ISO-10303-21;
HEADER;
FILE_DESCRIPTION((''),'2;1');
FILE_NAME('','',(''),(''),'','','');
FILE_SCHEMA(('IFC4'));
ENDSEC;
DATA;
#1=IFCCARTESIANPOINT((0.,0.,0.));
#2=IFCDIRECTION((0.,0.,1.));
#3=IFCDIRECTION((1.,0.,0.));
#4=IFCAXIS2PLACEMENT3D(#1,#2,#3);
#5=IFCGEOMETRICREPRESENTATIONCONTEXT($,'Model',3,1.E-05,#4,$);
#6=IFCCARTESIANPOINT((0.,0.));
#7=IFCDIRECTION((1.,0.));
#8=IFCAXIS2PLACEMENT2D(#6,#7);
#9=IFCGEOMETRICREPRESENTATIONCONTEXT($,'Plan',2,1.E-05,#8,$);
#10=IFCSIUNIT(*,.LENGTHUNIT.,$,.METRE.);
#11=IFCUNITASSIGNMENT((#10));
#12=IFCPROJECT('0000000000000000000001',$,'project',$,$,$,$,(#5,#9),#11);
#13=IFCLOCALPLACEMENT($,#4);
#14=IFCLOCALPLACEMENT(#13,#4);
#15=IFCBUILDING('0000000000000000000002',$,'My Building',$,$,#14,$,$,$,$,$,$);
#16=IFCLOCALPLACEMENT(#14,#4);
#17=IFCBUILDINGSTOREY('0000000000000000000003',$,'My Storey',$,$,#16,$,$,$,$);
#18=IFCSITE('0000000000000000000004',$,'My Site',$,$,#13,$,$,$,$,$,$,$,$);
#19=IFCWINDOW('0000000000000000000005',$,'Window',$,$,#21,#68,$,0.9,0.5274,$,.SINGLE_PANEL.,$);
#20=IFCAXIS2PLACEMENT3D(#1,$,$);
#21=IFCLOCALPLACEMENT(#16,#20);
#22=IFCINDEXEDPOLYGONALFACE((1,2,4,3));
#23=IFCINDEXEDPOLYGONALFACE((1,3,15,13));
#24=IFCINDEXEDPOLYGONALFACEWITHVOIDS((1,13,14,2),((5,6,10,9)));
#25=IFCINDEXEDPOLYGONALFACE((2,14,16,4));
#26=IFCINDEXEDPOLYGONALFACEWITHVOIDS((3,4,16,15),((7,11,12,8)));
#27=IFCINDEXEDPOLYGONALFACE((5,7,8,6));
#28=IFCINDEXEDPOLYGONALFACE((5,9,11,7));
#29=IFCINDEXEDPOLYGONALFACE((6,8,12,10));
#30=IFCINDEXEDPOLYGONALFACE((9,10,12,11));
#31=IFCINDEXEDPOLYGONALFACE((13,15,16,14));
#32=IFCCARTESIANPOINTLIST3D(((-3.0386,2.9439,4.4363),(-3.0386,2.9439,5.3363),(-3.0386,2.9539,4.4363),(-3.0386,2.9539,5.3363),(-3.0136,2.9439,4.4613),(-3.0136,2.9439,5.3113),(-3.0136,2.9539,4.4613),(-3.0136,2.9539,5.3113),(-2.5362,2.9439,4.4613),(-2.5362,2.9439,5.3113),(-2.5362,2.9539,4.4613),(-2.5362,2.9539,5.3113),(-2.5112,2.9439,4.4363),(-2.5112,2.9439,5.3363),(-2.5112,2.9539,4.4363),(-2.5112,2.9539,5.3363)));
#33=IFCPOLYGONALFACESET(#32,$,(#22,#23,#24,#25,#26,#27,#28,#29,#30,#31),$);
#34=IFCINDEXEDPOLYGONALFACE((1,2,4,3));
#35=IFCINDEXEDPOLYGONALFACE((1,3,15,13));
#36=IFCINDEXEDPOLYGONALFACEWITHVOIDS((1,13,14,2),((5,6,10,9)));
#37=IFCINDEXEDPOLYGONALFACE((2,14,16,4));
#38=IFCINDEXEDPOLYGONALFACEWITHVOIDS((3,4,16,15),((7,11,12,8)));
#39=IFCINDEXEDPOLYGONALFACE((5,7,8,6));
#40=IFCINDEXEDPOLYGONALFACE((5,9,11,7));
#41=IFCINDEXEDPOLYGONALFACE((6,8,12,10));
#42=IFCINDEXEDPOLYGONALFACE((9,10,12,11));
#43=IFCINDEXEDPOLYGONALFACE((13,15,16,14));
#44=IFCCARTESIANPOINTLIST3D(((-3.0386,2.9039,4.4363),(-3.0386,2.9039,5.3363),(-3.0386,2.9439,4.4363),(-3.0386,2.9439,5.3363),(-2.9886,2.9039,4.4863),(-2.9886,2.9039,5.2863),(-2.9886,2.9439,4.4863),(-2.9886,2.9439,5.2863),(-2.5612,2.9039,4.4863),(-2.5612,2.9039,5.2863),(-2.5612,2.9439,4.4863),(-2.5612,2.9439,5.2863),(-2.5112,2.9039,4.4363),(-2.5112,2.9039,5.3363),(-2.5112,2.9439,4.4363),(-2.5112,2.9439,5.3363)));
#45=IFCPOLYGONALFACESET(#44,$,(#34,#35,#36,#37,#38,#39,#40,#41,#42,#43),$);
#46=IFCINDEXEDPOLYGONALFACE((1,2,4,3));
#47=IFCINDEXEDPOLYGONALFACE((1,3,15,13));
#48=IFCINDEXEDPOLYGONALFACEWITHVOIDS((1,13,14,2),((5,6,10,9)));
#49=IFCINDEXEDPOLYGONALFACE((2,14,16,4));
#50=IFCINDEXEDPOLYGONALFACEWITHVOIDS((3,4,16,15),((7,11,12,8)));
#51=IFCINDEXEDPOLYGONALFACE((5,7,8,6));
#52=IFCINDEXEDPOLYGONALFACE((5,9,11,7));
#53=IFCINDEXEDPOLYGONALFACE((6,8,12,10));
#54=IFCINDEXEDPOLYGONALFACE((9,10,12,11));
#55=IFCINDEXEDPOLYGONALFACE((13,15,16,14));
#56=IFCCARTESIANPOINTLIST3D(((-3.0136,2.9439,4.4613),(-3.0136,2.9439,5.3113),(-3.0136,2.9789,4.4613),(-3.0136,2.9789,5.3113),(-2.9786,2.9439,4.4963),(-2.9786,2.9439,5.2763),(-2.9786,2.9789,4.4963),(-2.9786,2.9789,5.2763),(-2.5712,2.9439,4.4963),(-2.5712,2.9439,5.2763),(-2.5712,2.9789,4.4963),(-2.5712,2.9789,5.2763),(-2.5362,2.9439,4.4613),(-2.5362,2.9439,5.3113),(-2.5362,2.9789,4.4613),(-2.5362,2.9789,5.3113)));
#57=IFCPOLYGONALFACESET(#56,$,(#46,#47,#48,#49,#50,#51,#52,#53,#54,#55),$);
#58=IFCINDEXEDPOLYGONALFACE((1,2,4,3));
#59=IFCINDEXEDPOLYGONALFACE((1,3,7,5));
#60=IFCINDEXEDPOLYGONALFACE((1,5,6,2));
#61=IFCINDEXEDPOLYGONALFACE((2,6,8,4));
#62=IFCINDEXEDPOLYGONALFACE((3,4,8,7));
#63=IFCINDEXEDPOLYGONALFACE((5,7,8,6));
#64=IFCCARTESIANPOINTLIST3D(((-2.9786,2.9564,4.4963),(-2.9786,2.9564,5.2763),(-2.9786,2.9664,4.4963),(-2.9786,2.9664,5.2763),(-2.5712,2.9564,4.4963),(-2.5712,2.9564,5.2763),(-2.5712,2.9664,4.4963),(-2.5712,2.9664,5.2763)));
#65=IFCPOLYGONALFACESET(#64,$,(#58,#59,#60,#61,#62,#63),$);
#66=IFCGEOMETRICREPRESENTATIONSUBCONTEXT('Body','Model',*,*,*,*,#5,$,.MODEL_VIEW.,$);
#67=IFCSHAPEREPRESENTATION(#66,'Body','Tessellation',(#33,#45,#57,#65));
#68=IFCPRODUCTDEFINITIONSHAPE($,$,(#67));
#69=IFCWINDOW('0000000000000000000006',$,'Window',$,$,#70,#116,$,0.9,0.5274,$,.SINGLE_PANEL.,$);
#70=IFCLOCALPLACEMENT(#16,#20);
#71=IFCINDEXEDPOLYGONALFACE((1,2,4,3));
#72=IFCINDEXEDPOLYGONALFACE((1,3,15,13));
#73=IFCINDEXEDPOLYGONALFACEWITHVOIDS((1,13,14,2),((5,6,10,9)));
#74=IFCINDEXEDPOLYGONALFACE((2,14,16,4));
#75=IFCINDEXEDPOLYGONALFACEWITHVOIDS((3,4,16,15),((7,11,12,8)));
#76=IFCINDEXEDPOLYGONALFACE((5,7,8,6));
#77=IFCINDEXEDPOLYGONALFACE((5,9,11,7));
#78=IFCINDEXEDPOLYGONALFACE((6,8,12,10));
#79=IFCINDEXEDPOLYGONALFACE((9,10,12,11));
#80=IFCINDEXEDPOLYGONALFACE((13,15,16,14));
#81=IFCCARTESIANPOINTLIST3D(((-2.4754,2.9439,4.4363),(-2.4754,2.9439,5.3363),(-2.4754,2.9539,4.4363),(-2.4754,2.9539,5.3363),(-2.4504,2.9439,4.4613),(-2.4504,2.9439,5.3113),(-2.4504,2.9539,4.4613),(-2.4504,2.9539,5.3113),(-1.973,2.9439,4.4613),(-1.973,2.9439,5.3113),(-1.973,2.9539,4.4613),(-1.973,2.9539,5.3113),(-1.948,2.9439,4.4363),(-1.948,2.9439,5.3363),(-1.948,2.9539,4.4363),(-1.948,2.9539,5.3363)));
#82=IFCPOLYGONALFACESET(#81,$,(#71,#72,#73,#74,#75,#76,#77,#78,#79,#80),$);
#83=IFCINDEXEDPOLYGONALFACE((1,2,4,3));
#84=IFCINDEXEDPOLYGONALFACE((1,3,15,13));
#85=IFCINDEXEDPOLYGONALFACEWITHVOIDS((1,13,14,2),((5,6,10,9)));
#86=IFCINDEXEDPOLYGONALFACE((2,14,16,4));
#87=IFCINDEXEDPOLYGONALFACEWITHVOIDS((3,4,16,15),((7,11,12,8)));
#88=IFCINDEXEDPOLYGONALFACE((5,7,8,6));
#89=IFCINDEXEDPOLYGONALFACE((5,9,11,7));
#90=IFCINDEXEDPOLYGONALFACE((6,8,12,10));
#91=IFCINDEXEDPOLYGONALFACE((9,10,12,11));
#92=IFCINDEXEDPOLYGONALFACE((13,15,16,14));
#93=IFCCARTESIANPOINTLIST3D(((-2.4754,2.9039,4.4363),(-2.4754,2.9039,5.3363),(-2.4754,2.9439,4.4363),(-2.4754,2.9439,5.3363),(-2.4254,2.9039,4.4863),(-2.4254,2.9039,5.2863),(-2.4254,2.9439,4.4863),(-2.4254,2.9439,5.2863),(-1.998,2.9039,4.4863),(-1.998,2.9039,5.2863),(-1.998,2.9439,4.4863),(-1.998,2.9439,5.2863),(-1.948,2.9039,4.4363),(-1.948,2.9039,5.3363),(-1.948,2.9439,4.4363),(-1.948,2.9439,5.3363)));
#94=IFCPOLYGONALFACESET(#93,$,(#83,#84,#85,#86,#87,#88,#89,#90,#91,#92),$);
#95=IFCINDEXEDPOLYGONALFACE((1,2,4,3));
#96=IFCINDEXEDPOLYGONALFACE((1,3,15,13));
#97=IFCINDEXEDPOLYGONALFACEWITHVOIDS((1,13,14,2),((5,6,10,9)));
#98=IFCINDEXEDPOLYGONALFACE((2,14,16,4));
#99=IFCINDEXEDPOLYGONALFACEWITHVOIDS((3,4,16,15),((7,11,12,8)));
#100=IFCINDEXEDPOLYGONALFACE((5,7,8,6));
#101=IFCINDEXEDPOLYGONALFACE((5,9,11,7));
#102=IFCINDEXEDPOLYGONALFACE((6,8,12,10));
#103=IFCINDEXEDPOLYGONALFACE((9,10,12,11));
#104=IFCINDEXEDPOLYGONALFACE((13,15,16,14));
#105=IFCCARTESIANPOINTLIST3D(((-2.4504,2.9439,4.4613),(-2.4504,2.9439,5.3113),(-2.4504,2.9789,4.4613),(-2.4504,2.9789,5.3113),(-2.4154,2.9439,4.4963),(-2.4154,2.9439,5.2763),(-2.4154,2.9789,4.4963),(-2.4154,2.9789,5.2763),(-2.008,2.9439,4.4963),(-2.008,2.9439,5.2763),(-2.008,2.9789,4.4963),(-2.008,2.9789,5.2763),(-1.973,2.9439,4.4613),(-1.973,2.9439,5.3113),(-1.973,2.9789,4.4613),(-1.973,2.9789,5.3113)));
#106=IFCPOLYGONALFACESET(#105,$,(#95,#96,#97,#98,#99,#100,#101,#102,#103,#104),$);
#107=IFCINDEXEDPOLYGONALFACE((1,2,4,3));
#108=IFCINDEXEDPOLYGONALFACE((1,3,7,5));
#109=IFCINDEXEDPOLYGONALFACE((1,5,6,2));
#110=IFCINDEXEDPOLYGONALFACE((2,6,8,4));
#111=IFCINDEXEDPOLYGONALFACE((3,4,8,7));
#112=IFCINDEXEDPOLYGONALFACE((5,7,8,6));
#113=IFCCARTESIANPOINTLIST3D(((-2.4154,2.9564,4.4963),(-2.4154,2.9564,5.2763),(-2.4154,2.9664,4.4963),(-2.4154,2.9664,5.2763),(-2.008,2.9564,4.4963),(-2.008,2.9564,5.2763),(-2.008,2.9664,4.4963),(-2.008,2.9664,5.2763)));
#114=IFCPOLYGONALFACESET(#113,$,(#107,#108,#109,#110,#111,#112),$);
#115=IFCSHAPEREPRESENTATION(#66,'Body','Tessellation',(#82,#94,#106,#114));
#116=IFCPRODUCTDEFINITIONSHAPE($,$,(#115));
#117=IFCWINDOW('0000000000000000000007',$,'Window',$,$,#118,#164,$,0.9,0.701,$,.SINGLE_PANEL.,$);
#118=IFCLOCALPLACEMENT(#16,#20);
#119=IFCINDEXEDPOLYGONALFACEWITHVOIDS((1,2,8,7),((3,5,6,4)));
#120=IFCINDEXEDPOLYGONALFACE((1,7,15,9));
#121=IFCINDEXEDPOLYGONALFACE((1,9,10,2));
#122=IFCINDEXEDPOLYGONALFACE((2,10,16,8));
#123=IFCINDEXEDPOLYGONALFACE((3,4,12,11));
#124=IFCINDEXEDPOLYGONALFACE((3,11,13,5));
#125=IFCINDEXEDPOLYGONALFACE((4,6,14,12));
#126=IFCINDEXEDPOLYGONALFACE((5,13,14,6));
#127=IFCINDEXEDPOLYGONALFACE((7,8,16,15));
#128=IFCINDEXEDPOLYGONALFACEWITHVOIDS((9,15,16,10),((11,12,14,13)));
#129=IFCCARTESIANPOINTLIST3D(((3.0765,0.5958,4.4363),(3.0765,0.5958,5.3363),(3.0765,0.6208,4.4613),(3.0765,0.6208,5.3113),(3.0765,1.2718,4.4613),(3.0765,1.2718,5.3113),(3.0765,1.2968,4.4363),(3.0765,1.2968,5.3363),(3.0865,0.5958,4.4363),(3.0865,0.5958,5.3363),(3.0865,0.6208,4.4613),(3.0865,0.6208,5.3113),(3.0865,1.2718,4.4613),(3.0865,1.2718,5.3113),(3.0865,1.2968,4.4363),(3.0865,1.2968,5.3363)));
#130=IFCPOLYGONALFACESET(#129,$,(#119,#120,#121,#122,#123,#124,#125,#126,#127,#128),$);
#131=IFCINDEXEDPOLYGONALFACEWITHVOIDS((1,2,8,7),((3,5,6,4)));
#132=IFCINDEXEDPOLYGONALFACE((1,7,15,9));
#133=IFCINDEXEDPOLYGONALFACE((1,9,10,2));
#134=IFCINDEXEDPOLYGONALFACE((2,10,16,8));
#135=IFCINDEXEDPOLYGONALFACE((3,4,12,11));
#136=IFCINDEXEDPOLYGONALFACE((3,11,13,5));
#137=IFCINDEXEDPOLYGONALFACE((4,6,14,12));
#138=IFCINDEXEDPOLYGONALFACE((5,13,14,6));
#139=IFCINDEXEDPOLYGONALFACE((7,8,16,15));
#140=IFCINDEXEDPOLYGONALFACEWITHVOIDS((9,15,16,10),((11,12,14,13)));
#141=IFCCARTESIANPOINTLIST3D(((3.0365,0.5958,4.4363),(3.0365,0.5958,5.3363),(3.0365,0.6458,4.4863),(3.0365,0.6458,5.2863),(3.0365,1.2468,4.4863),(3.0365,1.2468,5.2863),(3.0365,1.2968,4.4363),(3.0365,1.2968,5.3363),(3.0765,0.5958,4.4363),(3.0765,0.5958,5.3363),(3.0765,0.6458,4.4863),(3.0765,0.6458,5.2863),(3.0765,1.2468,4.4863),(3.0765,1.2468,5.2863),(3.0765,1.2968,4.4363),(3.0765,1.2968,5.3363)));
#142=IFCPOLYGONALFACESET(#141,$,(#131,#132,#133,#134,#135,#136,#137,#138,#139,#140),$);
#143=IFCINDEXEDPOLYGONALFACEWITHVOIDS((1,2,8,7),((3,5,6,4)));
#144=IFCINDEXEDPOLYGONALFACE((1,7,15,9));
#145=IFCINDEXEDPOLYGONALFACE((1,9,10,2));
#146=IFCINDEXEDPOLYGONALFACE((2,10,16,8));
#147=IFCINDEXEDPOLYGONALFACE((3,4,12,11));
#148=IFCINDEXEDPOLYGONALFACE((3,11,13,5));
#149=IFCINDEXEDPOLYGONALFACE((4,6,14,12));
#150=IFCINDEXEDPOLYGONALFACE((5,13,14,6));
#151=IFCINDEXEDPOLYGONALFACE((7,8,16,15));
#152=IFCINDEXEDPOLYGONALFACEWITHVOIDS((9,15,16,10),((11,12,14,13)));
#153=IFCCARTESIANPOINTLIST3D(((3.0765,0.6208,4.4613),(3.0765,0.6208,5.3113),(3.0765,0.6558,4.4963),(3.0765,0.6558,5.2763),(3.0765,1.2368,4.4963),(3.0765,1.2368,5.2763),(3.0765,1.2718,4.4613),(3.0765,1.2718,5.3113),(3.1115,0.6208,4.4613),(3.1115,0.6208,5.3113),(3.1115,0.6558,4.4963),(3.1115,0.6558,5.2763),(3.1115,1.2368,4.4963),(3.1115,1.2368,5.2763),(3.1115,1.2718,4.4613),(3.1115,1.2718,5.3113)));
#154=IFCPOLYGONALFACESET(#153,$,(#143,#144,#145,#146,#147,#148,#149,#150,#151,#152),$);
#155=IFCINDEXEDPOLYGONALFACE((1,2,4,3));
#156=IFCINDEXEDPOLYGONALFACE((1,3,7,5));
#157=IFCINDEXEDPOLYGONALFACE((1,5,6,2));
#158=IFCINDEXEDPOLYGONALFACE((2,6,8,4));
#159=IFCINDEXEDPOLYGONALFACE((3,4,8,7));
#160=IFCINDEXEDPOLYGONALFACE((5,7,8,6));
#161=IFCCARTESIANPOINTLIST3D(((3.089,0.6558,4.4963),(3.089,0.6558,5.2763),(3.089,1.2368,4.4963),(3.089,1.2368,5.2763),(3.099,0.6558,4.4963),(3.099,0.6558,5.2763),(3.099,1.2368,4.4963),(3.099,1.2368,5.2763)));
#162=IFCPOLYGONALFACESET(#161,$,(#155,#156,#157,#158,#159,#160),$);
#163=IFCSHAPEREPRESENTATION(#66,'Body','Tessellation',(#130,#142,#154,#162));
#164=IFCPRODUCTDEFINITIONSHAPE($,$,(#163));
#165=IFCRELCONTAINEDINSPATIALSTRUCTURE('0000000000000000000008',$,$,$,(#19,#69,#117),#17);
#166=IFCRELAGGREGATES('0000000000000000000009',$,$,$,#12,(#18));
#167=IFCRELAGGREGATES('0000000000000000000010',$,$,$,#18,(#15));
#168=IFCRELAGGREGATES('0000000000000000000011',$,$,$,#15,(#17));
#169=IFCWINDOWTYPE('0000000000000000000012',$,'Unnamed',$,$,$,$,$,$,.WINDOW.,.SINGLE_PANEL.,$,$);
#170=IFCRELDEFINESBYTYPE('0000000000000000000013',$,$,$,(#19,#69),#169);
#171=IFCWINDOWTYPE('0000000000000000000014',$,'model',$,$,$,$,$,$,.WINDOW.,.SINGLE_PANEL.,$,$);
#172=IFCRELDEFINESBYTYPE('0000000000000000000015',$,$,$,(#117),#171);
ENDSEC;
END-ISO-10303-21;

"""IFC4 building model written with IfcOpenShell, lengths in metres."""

from ifc_helpers import new_model, entity, si_unit, frame, origin_with_axes, origin_2d_with_axis, place, context, subcontext, project, spatial, line, indexed_curve, outline, extrude, shape, source, transform, mapped, type_object, type_shapes, element, save


model = new_model("IFC4")

# Units and contexts
model_context = context("Model", 3, precision=1e-05, world=origin_with_axes())
plan_context = context("Plan", 2, precision=1e-05, world=origin_2d_with_axis())
body_context_1 = subcontext(model_context, "Body", "Model", "MODEL_VIEW")
body_context_2 = subcontext(plan_context, "Body", "Plan", "PLAN_VIEW")
ifc_project = project(units=[si_unit("LENGTHUNIT", "METRE")], contexts=[model_context, plan_context])

# Site, building, storey
site_placement = place(None, origin_with_axes())
site = spatial("IfcSite", under=ifc_project, at=site_placement, Name="My Site")
building_placement = place(site_placement, origin_with_axes())
building = spatial("IfcBuilding", under=site, at=building_placement, Name="My Building")
storey_placement = place(building_placement, origin_with_axes())
storey = spatial("IfcBuildingStorey", under=building, at=storey_placement, Name="My Storey")

# Shared definitions
window_type_1 = type_object("IfcWindowType", Name="Unnamed", PartitioningType="SINGLE_PANEL", PredefinedType="WINDOW")
shared_shape_1 = source(origin_with_axes(), body_context_1, "Body", "SweptSolid", [
    extrude(outline(indexed_curve([(0.0, 0.0), (0.5274, 0.0), (0.5274, 0.9), (0.0, 0.9)], segments=[line(1, 2, 3, 4, 1)]), holes=[indexed_curve([(0.025, 0.025), (0.5024, 0.025), (0.5024, 0.875), (0.025, 0.875)], segments=[line(1, 2, 3, 4, 1)])]), frame((0.0, 0.09, 0.0), z_axis=(0.0, -1.0, 0.0), x_axis=(1.0, 0.0, 0.0)), (0.0, 0.0, -1.0), 0.01),
    extrude(outline(indexed_curve([(0.0, 0.0), (0.5274, 0.0), (0.5274, 0.9), (0.0, 0.9)], segments=[line(1, 2, 3, 4, 1)]), holes=[indexed_curve([(0.05, 0.05), (0.4774, 0.05), (0.4774, 0.85), (0.05, 0.85)], segments=[line(1, 2, 3, 4, 1)])]), frame((0.0, 0.05, 0.0), z_axis=(0.0, -1.0, 0.0), x_axis=(1.0, 0.0, 0.0)), (0.0, 0.0, -1.0), 0.04),
    extrude(outline(indexed_curve([(0.0, 0.0), (0.4774, 0.0), (0.4774, 0.85), (0.0, 0.85)], segments=[line(1, 2, 3, 4, 1)]), holes=[indexed_curve([(0.035, 0.035), (0.4424, 0.035), (0.4424, 0.815), (0.035, 0.815)], segments=[line(1, 2, 3, 4, 1)])]), frame((0.025, 0.09, 0.025), z_axis=(0.0, -1.0, 0.0), x_axis=(1.0, 0.0, 0.0)), (0.0, 0.0, -1.0), 0.035),
    extrude(outline(indexed_curve([(0.035, 0.035), (0.4424, 0.035), (0.4424, 0.815), (0.035, 0.815)], segments=[line(1, 2, 3, 4, 1)])), frame((0.025, 0.1025, 0.025), z_axis=(0.0, -1.0, 0.0), x_axis=(1.0, 0.0, 0.0)), (0.0, 0.0, -1.0), 0.01),
])
shared_shape_2 = source(origin_with_axes(), body_context_2, "Body", "Curve2D", [
    entity("IfcIndexedPolyCurve", entity("IfcCartesianPointList2D", [[0.05, 0.05], [0.4774, 0.05]])),
    entity("IfcIndexedPolyCurve", entity("IfcCartesianPointList2D", [[0.0, 0.1], [0.025, 0.1], [0.025, 0.09], [0.05, 0.09], [0.05, 0.05], [0.0, 0.05]]), [entity("IfcLineIndex", [1, 2, 3, 4, 5, 6, 1])]),
    entity("IfcIndexedPolyCurve", entity("IfcCartesianPointList2D", [[0.5274, 0.1], [0.5024, 0.1], [0.5024, 0.09], [0.4774, 0.09], [0.4774, 0.05], [0.5274, 0.05]]), [entity("IfcLineIndex", [1, 2, 3, 4, 5, 6, 1])]),
    entity("IfcIndexedPolyCurve", entity("IfcCartesianPointList2D", [[0.025, 0.09], [0.06, 0.09], [0.06, 0.125], [0.025, 0.125]]), [entity("IfcLineIndex", [1, 2, 3, 4, 1])]),
    entity("IfcIndexedPolyCurve", entity("IfcCartesianPointList2D", [[0.5024, 0.09], [0.4674, 0.09], [0.4674, 0.125], [0.5024, 0.125]]), [entity("IfcLineIndex", [1, 2, 3, 4, 1])]),
    entity("IfcIndexedPolyCurve", entity("IfcCartesianPointList2D", [[0.06, 0.09], [0.4674, 0.09]])),
    entity("IfcIndexedPolyCurve", entity("IfcCartesianPointList2D", [[0.06, 0.125], [0.4674, 0.125]])),
    entity("IfcIndexedPolyCurve", entity("IfcCartesianPointList2D", [[0.06, 0.1075], [0.4674, 0.1075]])),
])
type_shapes(window_type_1, [shared_shape_1, shared_shape_2])

# Windows
for number, where, z_axis, x_axis, name in (
    (1, (-3.0386, 2.8539, 4.4363), (0.0, 0.0, 1.0), (1.0, 0.0, 0.0), "Window"),
    (2, (-2.4754, 2.8539, 4.4363), (0.0, 0.0, 1.0), (1.0, 0.0, 0.0), "Window"),
):
    element("IfcWindow", number, at=place(storey_placement, frame(where, z_axis=z_axis, x_axis=x_axis)), inside=storey, type_object=window_type_1, Name=name, OverallHeight=0.9, OverallWidth=0.5274, PartitioningType="SINGLE_PANEL", shapes=[
        shape(body_context_1, "Body", "MappedRepresentation", [mapped(shared_shape_1, transform((0.0, 0.0, 0.0), x_axis=(1.0, 0.0, 0.0), y_axis=(0.0, 1.0, 0.0), z_axis=(0.0, 0.0, 1.0), scale=1.0))]),
        shape(body_context_2, "Body", "MappedRepresentation", [mapped(shared_shape_2, transform((0.0, 0.0, 0.0), x_axis=(1.0, 0.0, 0.0), y_axis=(0.0, 1.0, 0.0), z_axis=(0.0, 0.0, 1.0), scale=1.0))]),
    ])
window_type_2 = type_object("IfcWindowType", Name="model", PartitioningType="SINGLE_PANEL", PredefinedType="WINDOW")
shared_shape_3 = source(origin_with_axes(), body_context_1, "Body", "SweptSolid", [
    extrude(outline(indexed_curve([(0.0, 0.0), (0.701, 0.0), (0.701, 0.9), (0.0, 0.9)], segments=[line(1, 2, 3, 4, 1)]), holes=[indexed_curve([(0.025, 0.025), (0.676, 0.025), (0.676, 0.875), (0.025, 0.875)], segments=[line(1, 2, 3, 4, 1)])]), frame((0.0, 0.09, 0.0), z_axis=(0.0, -1.0, 0.0), x_axis=(1.0, 0.0, 0.0)), (0.0, 0.0, -1.0), 0.01),
    extrude(outline(indexed_curve([(0.0, 0.0), (0.701, 0.0), (0.701, 0.9), (0.0, 0.9)], segments=[line(1, 2, 3, 4, 1)]), holes=[indexed_curve([(0.05, 0.05), (0.651, 0.05), (0.651, 0.85), (0.05, 0.85)], segments=[line(1, 2, 3, 4, 1)])]), frame((0.0, 0.05, 0.0), z_axis=(0.0, -1.0, 0.0), x_axis=(1.0, 0.0, 0.0)), (0.0, 0.0, -1.0), 0.04),
    extrude(outline(indexed_curve([(0.0, 0.0), (0.651, 0.0), (0.651, 0.85), (0.0, 0.85)], segments=[line(1, 2, 3, 4, 1)]), holes=[indexed_curve([(0.035, 0.035), (0.616, 0.035), (0.616, 0.815), (0.035, 0.815)], segments=[line(1, 2, 3, 4, 1)])]), frame((0.025, 0.09, 0.025), z_axis=(0.0, -1.0, 0.0), x_axis=(1.0, 0.0, 0.0)), (0.0, 0.0, -1.0), 0.035),
    extrude(outline(indexed_curve([(0.035, 0.035), (0.616, 0.035), (0.616, 0.815), (0.035, 0.815)], segments=[line(1, 2, 3, 4, 1)])), frame((0.025, 0.1025, 0.025), z_axis=(0.0, -1.0, 0.0), x_axis=(1.0, 0.0, 0.0)), (0.0, 0.0, -1.0), 0.01),
])
shared_shape_4 = source(origin_with_axes(), body_context_2, "Body", "Curve2D", [
    entity("IfcIndexedPolyCurve", entity("IfcCartesianPointList2D", [[0.05, 0.05], [0.651, 0.05]])),
    entity("IfcIndexedPolyCurve", entity("IfcCartesianPointList2D", [[0.0, 0.1], [0.025, 0.1], [0.025, 0.09], [0.05, 0.09], [0.05, 0.05], [0.0, 0.05]]), [entity("IfcLineIndex", [1, 2, 3, 4, 5, 6, 1])]),
    entity("IfcIndexedPolyCurve", entity("IfcCartesianPointList2D", [[0.701, 0.1], [0.676, 0.1], [0.676, 0.09], [0.651, 0.09], [0.651, 0.05], [0.701, 0.05]]), [entity("IfcLineIndex", [1, 2, 3, 4, 5, 6, 1])]),
    entity("IfcIndexedPolyCurve", entity("IfcCartesianPointList2D", [[0.025, 0.09], [0.06, 0.09], [0.06, 0.125], [0.025, 0.125]]), [entity("IfcLineIndex", [1, 2, 3, 4, 1])]),
    entity("IfcIndexedPolyCurve", entity("IfcCartesianPointList2D", [[0.676, 0.09], [0.641, 0.09], [0.641, 0.125], [0.676, 0.125]]), [entity("IfcLineIndex", [1, 2, 3, 4, 1])]),
    entity("IfcIndexedPolyCurve", entity("IfcCartesianPointList2D", [[0.06, 0.09], [0.641, 0.09]])),
    entity("IfcIndexedPolyCurve", entity("IfcCartesianPointList2D", [[0.06, 0.125], [0.641, 0.125]])),
    entity("IfcIndexedPolyCurve", entity("IfcCartesianPointList2D", [[0.06, 0.1075], [0.641, 0.1075]])),
])
type_shapes(window_type_2, [shared_shape_3, shared_shape_4])
for number, where, z_axis, x_axis, name in (
    (3, (2.9865, 1.2968, 4.4363), (0.0, 0.0, 1.0), (0.0, -1.0, 0.0), "Window"),
):
    element("IfcWindow", number, at=place(storey_placement, frame(where, z_axis=z_axis, x_axis=x_axis)), inside=storey, type_object=window_type_2, Name=name, OverallHeight=0.9, OverallWidth=0.701, PartitioningType="SINGLE_PANEL", shapes=[
        shape(body_context_1, "Body", "MappedRepresentation", [mapped(shared_shape_3, transform((0.0, 0.0, 0.0), x_axis=(1.0, 0.0, 0.0), y_axis=(0.0, 1.0, 0.0), z_axis=(0.0, 0.0, 1.0), scale=1.0))]),
        shape(body_context_2, "Body", "MappedRepresentation", [mapped(shared_shape_4, transform((0.0, 0.0, 0.0), x_axis=(1.0, 0.0, 0.0), y_axis=(0.0, 1.0, 0.0), z_axis=(0.0, 0.0, 1.0), scale=1.0))]),
    ])

save(model, "model.ifc")
